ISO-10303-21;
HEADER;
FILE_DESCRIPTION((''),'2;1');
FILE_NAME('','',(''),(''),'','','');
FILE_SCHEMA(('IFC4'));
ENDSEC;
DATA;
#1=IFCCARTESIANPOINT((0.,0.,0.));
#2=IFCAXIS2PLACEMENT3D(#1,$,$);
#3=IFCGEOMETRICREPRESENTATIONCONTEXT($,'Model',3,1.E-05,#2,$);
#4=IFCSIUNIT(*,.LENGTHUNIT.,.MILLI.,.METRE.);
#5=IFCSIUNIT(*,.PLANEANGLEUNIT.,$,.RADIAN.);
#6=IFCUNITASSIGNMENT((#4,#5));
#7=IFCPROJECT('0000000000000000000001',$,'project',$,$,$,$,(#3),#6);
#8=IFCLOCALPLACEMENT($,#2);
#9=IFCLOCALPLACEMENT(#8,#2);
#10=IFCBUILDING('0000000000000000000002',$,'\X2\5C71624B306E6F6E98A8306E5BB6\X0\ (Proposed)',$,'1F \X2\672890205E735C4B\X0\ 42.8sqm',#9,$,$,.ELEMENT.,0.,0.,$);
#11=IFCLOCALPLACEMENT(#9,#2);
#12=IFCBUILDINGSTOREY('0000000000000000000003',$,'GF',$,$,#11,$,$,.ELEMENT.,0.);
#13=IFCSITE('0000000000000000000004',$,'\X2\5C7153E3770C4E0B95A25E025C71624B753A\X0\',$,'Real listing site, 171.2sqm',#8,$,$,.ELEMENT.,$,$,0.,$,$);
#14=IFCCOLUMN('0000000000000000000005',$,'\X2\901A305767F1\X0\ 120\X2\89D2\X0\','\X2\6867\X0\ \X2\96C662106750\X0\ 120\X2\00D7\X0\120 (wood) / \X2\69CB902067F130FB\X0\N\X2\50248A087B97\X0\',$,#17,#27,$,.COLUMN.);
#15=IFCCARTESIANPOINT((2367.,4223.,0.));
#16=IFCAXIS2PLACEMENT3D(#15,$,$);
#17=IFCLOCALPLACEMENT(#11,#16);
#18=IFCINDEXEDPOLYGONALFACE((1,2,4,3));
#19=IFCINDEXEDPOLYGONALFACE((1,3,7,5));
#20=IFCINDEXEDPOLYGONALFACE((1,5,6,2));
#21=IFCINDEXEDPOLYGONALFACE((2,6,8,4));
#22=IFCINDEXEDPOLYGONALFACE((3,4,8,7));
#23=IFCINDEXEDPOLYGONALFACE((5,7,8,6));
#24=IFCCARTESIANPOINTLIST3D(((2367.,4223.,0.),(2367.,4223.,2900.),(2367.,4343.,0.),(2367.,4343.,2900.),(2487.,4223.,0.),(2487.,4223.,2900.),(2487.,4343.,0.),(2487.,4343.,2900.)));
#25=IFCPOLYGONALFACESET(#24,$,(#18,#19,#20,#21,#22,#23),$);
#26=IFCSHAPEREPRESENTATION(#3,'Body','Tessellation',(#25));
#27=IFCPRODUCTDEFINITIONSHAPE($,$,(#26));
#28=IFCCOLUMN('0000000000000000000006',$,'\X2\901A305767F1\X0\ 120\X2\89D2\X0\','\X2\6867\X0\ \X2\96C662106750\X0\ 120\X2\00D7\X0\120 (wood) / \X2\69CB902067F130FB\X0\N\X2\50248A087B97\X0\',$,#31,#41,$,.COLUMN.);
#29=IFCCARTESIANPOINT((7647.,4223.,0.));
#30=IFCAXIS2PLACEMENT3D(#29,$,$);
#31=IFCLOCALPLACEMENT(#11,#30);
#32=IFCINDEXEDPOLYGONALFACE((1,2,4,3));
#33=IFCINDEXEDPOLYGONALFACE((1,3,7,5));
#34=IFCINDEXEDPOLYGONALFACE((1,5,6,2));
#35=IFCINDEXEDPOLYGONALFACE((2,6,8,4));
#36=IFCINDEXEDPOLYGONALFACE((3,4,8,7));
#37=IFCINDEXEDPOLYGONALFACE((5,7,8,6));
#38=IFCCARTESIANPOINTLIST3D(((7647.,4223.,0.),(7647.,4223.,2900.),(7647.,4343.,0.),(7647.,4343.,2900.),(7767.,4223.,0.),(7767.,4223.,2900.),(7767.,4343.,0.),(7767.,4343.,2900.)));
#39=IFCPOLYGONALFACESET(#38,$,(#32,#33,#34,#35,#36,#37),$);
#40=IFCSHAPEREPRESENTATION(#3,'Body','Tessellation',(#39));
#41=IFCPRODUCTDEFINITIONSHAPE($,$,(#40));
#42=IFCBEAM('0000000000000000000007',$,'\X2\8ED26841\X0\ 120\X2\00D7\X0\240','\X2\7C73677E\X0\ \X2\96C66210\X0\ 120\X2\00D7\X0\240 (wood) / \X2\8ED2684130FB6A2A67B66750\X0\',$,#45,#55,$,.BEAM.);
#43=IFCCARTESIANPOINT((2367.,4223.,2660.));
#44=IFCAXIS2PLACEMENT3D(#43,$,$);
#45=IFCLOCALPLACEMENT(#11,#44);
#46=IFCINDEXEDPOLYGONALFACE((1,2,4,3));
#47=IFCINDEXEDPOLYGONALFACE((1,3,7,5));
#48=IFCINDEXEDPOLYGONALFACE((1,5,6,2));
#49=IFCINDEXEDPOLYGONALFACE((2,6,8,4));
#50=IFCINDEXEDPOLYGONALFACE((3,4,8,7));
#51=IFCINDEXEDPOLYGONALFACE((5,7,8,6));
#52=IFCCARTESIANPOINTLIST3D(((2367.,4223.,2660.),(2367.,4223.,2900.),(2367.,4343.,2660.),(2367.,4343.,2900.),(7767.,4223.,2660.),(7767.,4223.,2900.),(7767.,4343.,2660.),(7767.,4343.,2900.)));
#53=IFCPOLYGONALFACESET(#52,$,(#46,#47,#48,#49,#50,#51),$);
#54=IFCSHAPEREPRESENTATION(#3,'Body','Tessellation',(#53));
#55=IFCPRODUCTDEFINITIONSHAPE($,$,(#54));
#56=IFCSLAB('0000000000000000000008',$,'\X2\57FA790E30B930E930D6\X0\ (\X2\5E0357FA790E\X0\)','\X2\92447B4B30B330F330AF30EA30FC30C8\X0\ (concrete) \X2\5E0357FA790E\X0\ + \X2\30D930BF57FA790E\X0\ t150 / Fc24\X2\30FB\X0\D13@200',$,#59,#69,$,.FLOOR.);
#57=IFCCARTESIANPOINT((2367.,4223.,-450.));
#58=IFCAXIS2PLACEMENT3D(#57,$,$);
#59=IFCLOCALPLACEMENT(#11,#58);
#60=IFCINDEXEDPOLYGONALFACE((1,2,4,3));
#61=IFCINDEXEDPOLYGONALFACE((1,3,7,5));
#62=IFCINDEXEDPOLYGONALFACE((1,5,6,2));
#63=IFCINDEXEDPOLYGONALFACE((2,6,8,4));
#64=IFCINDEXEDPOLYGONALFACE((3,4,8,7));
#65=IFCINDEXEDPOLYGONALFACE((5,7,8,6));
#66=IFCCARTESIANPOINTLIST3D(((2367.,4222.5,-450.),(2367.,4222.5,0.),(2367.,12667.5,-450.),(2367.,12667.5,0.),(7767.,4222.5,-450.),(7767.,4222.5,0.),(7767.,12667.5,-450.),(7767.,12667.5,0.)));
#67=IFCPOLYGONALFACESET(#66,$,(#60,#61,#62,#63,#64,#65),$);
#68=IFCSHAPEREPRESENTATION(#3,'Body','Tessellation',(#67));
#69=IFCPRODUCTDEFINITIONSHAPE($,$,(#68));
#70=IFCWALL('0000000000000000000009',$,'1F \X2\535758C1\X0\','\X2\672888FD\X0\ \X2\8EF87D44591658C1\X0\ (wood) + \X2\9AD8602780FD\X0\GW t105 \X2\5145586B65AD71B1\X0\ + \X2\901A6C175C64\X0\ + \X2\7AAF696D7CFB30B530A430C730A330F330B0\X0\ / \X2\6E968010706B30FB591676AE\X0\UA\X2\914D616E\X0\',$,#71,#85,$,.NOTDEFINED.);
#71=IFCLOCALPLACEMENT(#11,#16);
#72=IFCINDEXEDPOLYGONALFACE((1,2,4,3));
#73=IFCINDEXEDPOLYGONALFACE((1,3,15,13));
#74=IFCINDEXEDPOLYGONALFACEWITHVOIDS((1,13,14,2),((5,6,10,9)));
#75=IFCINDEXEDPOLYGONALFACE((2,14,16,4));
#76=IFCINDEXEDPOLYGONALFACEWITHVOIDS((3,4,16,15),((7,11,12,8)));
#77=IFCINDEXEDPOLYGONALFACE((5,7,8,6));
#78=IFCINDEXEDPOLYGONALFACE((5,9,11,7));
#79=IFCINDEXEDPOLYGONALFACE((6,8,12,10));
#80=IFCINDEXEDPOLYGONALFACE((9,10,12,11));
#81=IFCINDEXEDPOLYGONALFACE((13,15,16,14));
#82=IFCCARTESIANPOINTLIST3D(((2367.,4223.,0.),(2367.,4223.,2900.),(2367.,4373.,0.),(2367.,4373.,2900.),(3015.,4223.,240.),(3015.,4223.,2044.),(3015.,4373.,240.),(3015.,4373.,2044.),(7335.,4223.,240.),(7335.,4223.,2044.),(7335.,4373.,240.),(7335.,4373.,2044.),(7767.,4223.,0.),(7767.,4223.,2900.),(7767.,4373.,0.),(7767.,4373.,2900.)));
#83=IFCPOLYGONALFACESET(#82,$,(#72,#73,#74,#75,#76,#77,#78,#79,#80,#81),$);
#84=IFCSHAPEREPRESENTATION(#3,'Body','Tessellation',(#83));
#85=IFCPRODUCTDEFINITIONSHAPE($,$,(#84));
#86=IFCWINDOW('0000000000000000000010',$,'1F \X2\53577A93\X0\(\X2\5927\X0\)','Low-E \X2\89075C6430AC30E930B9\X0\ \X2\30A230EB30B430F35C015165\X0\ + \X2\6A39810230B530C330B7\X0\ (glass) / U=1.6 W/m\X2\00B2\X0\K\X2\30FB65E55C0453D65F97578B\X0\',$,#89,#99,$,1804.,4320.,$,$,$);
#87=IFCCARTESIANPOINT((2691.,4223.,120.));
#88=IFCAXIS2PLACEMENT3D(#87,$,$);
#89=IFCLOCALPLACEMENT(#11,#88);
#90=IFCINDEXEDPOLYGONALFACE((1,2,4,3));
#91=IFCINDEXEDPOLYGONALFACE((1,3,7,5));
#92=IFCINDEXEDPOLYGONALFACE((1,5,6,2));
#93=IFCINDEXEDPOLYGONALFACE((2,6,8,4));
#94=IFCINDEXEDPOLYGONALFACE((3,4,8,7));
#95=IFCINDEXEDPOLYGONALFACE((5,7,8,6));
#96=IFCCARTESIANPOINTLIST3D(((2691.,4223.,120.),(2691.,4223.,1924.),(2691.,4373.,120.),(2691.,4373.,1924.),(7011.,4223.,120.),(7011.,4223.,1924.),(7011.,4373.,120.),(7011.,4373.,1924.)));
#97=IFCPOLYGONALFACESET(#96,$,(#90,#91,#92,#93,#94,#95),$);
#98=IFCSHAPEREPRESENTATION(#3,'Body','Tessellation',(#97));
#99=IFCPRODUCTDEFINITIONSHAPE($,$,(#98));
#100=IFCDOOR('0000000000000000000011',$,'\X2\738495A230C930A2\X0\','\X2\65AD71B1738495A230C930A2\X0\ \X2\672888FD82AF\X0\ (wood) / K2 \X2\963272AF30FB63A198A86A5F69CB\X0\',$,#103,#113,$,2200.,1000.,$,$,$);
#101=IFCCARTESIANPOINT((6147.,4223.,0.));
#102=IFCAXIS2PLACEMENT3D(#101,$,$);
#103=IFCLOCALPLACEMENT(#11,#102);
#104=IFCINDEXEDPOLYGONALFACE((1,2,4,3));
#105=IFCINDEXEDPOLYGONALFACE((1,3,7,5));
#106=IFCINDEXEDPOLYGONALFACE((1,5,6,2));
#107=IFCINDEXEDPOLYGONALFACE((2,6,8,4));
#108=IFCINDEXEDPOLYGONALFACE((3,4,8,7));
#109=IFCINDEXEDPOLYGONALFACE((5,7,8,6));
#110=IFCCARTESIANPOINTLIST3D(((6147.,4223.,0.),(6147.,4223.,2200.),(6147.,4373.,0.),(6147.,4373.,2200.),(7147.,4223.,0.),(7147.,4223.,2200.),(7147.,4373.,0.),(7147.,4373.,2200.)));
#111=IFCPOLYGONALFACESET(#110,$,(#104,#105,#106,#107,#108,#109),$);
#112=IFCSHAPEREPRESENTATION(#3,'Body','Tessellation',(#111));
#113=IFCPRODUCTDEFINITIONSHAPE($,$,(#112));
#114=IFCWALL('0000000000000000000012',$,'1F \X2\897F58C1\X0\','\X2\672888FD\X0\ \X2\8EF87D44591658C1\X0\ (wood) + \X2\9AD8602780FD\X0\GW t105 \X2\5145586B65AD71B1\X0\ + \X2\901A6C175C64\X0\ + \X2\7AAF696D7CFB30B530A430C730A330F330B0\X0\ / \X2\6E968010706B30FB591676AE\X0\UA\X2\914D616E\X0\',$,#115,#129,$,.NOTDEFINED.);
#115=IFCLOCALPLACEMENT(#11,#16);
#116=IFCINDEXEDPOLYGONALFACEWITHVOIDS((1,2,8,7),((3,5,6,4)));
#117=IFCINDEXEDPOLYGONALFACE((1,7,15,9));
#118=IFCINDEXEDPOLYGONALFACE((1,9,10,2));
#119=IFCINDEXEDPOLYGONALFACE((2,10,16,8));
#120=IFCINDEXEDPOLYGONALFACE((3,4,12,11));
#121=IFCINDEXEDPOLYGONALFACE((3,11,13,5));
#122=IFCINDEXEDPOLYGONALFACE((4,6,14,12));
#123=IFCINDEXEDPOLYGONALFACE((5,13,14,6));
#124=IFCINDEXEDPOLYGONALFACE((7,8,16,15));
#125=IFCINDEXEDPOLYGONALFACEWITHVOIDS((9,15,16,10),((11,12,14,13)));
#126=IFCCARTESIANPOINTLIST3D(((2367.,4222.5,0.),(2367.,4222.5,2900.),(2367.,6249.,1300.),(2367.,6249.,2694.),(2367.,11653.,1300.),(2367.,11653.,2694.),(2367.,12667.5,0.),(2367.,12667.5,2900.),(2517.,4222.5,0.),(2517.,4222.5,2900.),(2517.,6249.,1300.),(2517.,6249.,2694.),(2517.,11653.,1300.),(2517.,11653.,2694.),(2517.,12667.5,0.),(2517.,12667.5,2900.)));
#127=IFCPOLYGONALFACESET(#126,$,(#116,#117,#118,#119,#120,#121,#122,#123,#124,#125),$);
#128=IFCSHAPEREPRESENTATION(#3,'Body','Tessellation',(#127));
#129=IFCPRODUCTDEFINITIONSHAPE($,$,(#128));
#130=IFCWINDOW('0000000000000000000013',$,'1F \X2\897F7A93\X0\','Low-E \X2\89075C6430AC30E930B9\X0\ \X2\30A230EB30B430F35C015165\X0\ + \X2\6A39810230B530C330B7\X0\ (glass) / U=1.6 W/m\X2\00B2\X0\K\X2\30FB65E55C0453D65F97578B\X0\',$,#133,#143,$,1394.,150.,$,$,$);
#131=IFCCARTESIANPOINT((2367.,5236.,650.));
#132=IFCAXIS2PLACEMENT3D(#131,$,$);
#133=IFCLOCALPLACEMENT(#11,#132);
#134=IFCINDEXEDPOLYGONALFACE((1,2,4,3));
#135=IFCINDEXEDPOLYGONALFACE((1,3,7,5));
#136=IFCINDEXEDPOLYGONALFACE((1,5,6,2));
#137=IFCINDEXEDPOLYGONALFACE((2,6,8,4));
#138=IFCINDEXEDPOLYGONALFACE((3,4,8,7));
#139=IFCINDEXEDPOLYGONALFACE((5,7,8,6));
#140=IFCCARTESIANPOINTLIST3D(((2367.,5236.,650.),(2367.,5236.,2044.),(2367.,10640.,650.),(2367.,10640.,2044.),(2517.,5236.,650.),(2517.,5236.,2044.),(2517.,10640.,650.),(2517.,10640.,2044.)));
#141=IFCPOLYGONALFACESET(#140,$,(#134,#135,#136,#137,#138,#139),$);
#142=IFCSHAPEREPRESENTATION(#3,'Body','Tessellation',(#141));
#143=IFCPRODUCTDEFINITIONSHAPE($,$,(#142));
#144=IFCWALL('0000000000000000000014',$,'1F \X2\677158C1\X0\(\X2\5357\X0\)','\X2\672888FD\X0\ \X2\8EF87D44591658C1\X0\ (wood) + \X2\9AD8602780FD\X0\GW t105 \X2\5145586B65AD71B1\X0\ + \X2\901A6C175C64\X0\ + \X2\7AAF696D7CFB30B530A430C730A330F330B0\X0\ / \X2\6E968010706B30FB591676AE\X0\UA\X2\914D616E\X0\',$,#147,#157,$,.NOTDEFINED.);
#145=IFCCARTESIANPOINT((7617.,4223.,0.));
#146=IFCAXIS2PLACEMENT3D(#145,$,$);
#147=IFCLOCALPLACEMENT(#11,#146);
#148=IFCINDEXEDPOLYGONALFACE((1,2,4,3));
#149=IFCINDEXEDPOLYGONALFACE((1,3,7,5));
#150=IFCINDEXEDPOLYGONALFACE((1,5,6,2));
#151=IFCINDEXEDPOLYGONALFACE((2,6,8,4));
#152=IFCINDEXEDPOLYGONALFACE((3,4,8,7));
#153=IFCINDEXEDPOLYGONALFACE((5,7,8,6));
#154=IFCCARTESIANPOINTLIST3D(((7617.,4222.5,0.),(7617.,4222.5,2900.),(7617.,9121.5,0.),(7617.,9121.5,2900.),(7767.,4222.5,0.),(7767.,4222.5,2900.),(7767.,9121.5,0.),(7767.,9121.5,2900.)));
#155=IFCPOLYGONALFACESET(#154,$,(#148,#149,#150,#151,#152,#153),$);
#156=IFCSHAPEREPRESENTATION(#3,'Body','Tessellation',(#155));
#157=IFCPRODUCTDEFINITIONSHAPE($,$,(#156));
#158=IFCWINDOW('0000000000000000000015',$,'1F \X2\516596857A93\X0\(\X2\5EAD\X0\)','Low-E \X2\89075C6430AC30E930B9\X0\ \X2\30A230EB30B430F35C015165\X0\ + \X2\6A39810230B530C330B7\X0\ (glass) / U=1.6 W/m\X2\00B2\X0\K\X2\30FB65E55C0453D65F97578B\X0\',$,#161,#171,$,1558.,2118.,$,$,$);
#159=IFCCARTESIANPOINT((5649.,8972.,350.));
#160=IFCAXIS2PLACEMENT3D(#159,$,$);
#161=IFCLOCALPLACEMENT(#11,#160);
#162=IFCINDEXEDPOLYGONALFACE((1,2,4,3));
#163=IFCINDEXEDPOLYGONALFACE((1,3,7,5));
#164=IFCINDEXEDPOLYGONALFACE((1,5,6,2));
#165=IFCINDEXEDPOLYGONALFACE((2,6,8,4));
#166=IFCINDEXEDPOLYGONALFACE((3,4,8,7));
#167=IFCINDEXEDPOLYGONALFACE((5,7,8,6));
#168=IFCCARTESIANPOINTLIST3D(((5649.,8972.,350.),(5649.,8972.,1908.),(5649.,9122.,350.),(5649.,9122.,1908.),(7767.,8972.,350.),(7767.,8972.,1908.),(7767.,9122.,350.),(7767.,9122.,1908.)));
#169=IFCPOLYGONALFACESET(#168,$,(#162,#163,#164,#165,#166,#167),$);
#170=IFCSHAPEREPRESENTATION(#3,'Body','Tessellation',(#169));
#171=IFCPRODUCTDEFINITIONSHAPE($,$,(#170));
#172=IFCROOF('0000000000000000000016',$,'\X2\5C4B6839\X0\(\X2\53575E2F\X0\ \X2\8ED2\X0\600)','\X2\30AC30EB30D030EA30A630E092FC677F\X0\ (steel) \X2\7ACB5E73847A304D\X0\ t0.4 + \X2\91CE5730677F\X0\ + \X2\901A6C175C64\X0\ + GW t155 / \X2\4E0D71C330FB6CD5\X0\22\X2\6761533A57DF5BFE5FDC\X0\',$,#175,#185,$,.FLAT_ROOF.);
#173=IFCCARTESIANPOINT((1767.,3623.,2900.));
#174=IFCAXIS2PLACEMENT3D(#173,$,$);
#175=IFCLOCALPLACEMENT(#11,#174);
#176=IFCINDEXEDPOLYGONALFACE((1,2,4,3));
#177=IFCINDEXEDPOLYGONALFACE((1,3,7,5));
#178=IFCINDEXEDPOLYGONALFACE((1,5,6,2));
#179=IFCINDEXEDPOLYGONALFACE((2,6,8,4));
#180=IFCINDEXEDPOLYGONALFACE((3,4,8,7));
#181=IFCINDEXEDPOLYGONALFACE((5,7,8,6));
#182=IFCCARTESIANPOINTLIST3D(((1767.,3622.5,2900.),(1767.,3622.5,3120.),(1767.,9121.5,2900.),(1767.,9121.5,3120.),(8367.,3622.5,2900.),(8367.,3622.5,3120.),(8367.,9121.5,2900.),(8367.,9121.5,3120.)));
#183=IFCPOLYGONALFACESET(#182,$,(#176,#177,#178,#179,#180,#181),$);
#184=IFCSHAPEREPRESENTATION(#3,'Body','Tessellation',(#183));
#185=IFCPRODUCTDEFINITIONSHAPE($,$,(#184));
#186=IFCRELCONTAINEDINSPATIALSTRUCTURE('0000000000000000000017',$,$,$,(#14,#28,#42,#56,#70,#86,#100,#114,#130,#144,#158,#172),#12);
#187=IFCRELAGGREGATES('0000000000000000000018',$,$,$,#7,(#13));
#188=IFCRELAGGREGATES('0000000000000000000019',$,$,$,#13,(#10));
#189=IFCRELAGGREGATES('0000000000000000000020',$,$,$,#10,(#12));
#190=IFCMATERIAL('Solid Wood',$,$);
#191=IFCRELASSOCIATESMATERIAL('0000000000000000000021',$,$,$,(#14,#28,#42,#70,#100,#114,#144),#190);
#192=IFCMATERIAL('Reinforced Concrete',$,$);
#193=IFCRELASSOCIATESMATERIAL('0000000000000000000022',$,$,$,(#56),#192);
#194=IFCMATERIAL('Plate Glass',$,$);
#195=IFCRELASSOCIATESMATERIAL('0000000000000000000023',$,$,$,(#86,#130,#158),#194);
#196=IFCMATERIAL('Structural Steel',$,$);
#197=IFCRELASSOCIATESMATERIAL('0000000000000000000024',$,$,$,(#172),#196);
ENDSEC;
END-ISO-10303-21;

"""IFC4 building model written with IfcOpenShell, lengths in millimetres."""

from ifc_helpers import new_model, si_unit, frame, frame_2d, origin, place, context, project, spatial, rectangle, extrude, material, element, fill, save


model = new_model("IFC4")

# Units and contexts
model_context = context("Model", 3, precision=1e-05, world=origin())
ifc_project = project(units=[si_unit("LENGTHUNIT", "METRE", prefix="MILLI"), si_unit("PLANEANGLEUNIT", "RADIAN")], contexts=[model_context])

# Site, building, storey
site_placement = place(None, origin())
site = spatial("IfcSite", under=ifc_project, at=site_placement, Name="山口県下関市山手町", ObjectType="Real listing site, 171.2sqm", CompositionType="ELEMENT", RefElevation=0.0)
building_placement = place(site_placement, origin())
building = spatial("IfcBuilding", under=site, at=building_placement, Name="山手の潮風の家 (Proposed)", ObjectType="1F 木造平屋 42.8sqm", CompositionType="ELEMENT", ElevationOfRefHeight=0.0, ElevationOfTerrain=0.0)
storey_placement = place(building_placement, origin())
storey = spatial("IfcBuildingStorey", under=building, at=storey_placement, Name="GF", CompositionType="ELEMENT", Elevation=0.0)

# Columns
ifc_material_1 = material(Name="Solid Wood")
column_1_placement = place(storey_placement, frame((2367.0, 4223.0, 0.0)))
element("IfcColumn", 1, at=column_1_placement, inside=storey, material=ifc_material_1, Name="通し柱 120角", Description="桧 集成材 120×120 (wood) / 構造柱・N値計算", PredefinedType="COLUMN", context=model_context, shape_type="SweptSolid", body=[
    extrude(rectangle(XDim=120.0, YDim=120.0, at=frame_2d((60.0, 60.0))), frame((2367.0, 4223.0, 0.0)), (0.0, 0.0, 1.0), 2900.0),
])
column_2_placement = place(storey_placement, frame((7647.0, 4223.0, 0.0)))
element("IfcColumn", 2, at=column_2_placement, inside=storey, material=ifc_material_1, Name="通し柱 120角", Description="桧 集成材 120×120 (wood) / 構造柱・N値計算", PredefinedType="COLUMN", context=model_context, shape_type="SweptSolid", body=[
    extrude(rectangle(XDim=120.0, YDim=120.0, at=frame_2d((60.0, 60.0))), frame((7647.0, 4223.0, 0.0)), (0.0, 0.0, 1.0), 2900.0),
])

# Beam
beam_1_placement = place(storey_placement, frame((2367.0, 4223.0, 2660.0)))
element("IfcBeam", 3, at=beam_1_placement, inside=storey, material=ifc_material_1, Name="軒桁 120×240", Description="米松 集成 120×240 (wood) / 軒桁・横架材", PredefinedType="BEAM", context=model_context, shape_type="SweptSolid", body=[
    extrude(rectangle(XDim=5400.0, YDim=120.0, at=frame_2d((2700.0, 60.0))), frame((2367.0, 4223.0, 2660.0)), (0.0, 0.0, 1.0), 240.0),
])

# Slab
ifc_material_2 = material(Name="Reinforced Concrete")
slab_1_placement = place(storey_placement, frame((2367.0, 4223.0, -450.0)))
element("IfcSlab", 4, at=slab_1_placement, inside=storey, material=ifc_material_2, Name="基礎スラブ (布基礎)", Description="鉄筋コンクリート (concrete) 布基礎 + ベタ基礎 t150 / Fc24・D13@200", PredefinedType="FLOOR", context=model_context, shape_type="SweptSolid", body=[
    extrude(rectangle(XDim=5400.0, YDim=8445.0, at=frame_2d((2700.0, 4222.0))), frame((2367.0, 4223.0, -450.0)), (0.0, 0.0, 1.0), 450.0),
])

# Wall, openings, window, door
wall_1_placement = place(storey_placement, frame((2367.0, 4223.0, 0.0)))
wall_1 = element("IfcWall", 5, at=wall_1_placement, inside=storey, material=ifc_material_1, Name="1F 南壁", Description="木製 軸組外壁 (wood) + 高性能GW t105 充填断熱 + 通気層 + 窯業系サイディング / 準耐火・外皮UA配慮", PredefinedType="NOTDEFINED", context=model_context, shape_type="SweptSolid", body=[
    extrude(rectangle(XDim=5400.0, YDim=150.0, at=frame_2d((2700.0, 75.0))), frame((2367.0, 4223.0, 0.0)), (0.0, 0.0, 1.0), 2900.0),
])
opening_1_placement = place(storey_placement, frame((2691.0, 4223.0, 120.0)))
opening_1 = element("IfcOpeningElement", 6, at=opening_1_placement, cuts=wall_1, PredefinedType="NOTDEFINED", context=model_context, shape_type="SweptSolid", body=[
    extrude(rectangle(XDim=4320.0, YDim=150.0, at=frame_2d((2160.0, 75.0))), frame((2691.0, 4223.0, 120.0)), (0.0, 0.0, 1.0), 1804.0),
])
opening_2_placement = place(storey_placement, frame((6147.0, 4223.0, 0.0)))
opening_2 = element("IfcOpeningElement", 7, at=opening_2_placement, cuts=wall_1, PredefinedType="NOTDEFINED", context=model_context, shape_type="SweptSolid", body=[
    extrude(rectangle(XDim=1000.0, YDim=150.0, at=frame_2d((500.0, 75.0))), frame((6147.0, 4223.0, 0.0)), (0.0, 0.0, 1.0), 2200.0),
])
ifc_material_3 = material(Name="Plate Glass")
window_1_placement = place(storey_placement, frame((2691.0, 4223.0, 120.0)))
window_1 = element("IfcWindow", 8, at=window_1_placement, inside=storey, material=ifc_material_3, Name="1F 南窓(大)", Description="Low-E 複層ガラス アルゴン封入 + 樹脂サッシ (glass) / U=1.6 W/m²K・日射取得型", OverallHeight=1804.0, OverallWidth=4320.0, context=model_context, shape_type="SweptSolid", body=[
    extrude(rectangle(XDim=4320.0, YDim=150.0, at=frame_2d((2160.0, 75.0))), frame((2691.0, 4223.0, 120.0)), (0.0, 0.0, 1.0), 1804.0),
])
fill(opening_1, window_1)
door_1_placement = place(storey_placement, frame((6147.0, 4223.0, 0.0)))
door_1 = element("IfcDoor", 9, at=door_1_placement, inside=storey, material=ifc_material_1, Name="玄関ドア", Description="断熱玄関ドア 木製芯 (wood) / K2 防犯・採風機構", OverallHeight=2200.0, OverallWidth=1000.0, context=model_context, shape_type="SweptSolid", body=[
    extrude(rectangle(XDim=1000.0, YDim=150.0, at=frame_2d((500.0, 75.0))), frame((6147.0, 4223.0, 0.0)), (0.0, 0.0, 1.0), 2200.0),
])
fill(opening_2, door_1)

# Walls, openings, windows
wall_2_placement = place(storey_placement, frame((2367.0, 4223.0, 0.0)))
wall_2 = element("IfcWall", 10, at=wall_2_placement, inside=storey, material=ifc_material_1, Name="1F 西壁", Description="木製 軸組外壁 (wood) + 高性能GW t105 充填断熱 + 通気層 + 窯業系サイディング / 準耐火・外皮UA配慮", PredefinedType="NOTDEFINED", context=model_context, shape_type="SweptSolid", body=[
    extrude(rectangle(XDim=150.0, YDim=8445.0, at=frame_2d((75.0, 4222.0))), frame((2367.0, 4223.0, 0.0)), (0.0, 0.0, 1.0), 2900.0),
])
opening_3_placement = place(storey_placement, frame((2367.0, 5236.0, 650.0)))
opening_3 = element("IfcOpeningElement", 11, at=opening_3_placement, cuts=wall_2, PredefinedType="NOTDEFINED", context=model_context, shape_type="SweptSolid", body=[
    extrude(rectangle(XDim=150.0, YDim=5404.0, at=frame_2d((75.0, 2702.0))), frame((2367.0, 5236.0, 650.0)), (0.0, 0.0, 1.0), 1394.0),
])
window_2_placement = place(storey_placement, frame((2367.0, 5236.0, 650.0)))
window_2 = element("IfcWindow", 12, at=window_2_placement, inside=storey, material=ifc_material_3, Name="1F 西窓", Description="Low-E 複層ガラス アルゴン封入 + 樹脂サッシ (glass) / U=1.6 W/m²K・日射取得型", OverallHeight=1394.0, OverallWidth=150.0, context=model_context, shape_type="SweptSolid", body=[
    extrude(rectangle(XDim=150.0, YDim=5404.0, at=frame_2d((75.0, 2702.0))), frame((2367.0, 5236.0, 650.0)), (0.0, 0.0, 1.0), 1394.0),
])
fill(opening_3, window_2)
wall_3_placement = place(storey_placement, frame((7617.0, 4223.0, 0.0)))
wall_3 = element("IfcWall", 13, at=wall_3_placement, inside=storey, material=ifc_material_1, Name="1F 東壁(南)", Description="木製 軸組外壁 (wood) + 高性能GW t105 充填断熱 + 通気層 + 窯業系サイディング / 準耐火・外皮UA配慮", PredefinedType="NOTDEFINED", context=model_context, shape_type="SweptSolid", body=[
    extrude(rectangle(XDim=150.0, YDim=4899.0, at=frame_2d((75.0, 2449.0))), frame((7617.0, 4223.0, 0.0)), (0.0, 0.0, 1.0), 2900.0),
])
opening_4_placement = place(storey_placement, frame((5649.0, 8972.0, 350.0)))
opening_4 = element("IfcOpeningElement", 14, at=opening_4_placement, cuts=wall_3, PredefinedType="NOTDEFINED", context=model_context, shape_type="SweptSolid", body=[
    extrude(rectangle(XDim=2118.0, YDim=150.0, at=frame_2d((1059.0, 75.0))), frame((5649.0, 8972.0, 350.0)), (0.0, 0.0, 1.0), 1558.0),
])
window_3_placement = place(storey_placement, frame((5649.0, 8972.0, 350.0)))
window_3 = element("IfcWindow", 15, at=window_3_placement, inside=storey, material=ifc_material_3, Name="1F 入隅窓(庭)", Description="Low-E 複層ガラス アルゴン封入 + 樹脂サッシ (glass) / U=1.6 W/m²K・日射取得型", OverallHeight=1558.0, OverallWidth=2118.0, context=model_context, shape_type="SweptSolid", body=[
    extrude(rectangle(XDim=2118.0, YDim=150.0, at=frame_2d((1059.0, 75.0))), frame((5649.0, 8972.0, 350.0)), (0.0, 0.0, 1.0), 1558.0),
])
fill(opening_4, window_3)

# Roof
ifc_material_4 = material(Name="Structural Steel")
roof_placement = place(storey_placement, frame((1767.0, 3623.0, 2900.0)))
element("IfcRoof", 16, at=roof_placement, inside=storey, material=ifc_material_4, Name="屋根(南帯 軒600)", Description="ガルバリウム鋼板 (steel) 立平葺き t0.4 + 野地板 + 通気層 + GW t155 / 不燃・法22条区域対応", PredefinedType="FLAT_ROOF", context=model_context, shape_type="SweptSolid", body=[
    extrude(rectangle(XDim=6600.0, YDim=5499.0, at=frame_2d((3300.0, 2749.0))), frame((1767.0, 3623.0, 2900.0)), (0.0, 0.0, 1.0), 220.0),
])

save(model, "model.ifc")
